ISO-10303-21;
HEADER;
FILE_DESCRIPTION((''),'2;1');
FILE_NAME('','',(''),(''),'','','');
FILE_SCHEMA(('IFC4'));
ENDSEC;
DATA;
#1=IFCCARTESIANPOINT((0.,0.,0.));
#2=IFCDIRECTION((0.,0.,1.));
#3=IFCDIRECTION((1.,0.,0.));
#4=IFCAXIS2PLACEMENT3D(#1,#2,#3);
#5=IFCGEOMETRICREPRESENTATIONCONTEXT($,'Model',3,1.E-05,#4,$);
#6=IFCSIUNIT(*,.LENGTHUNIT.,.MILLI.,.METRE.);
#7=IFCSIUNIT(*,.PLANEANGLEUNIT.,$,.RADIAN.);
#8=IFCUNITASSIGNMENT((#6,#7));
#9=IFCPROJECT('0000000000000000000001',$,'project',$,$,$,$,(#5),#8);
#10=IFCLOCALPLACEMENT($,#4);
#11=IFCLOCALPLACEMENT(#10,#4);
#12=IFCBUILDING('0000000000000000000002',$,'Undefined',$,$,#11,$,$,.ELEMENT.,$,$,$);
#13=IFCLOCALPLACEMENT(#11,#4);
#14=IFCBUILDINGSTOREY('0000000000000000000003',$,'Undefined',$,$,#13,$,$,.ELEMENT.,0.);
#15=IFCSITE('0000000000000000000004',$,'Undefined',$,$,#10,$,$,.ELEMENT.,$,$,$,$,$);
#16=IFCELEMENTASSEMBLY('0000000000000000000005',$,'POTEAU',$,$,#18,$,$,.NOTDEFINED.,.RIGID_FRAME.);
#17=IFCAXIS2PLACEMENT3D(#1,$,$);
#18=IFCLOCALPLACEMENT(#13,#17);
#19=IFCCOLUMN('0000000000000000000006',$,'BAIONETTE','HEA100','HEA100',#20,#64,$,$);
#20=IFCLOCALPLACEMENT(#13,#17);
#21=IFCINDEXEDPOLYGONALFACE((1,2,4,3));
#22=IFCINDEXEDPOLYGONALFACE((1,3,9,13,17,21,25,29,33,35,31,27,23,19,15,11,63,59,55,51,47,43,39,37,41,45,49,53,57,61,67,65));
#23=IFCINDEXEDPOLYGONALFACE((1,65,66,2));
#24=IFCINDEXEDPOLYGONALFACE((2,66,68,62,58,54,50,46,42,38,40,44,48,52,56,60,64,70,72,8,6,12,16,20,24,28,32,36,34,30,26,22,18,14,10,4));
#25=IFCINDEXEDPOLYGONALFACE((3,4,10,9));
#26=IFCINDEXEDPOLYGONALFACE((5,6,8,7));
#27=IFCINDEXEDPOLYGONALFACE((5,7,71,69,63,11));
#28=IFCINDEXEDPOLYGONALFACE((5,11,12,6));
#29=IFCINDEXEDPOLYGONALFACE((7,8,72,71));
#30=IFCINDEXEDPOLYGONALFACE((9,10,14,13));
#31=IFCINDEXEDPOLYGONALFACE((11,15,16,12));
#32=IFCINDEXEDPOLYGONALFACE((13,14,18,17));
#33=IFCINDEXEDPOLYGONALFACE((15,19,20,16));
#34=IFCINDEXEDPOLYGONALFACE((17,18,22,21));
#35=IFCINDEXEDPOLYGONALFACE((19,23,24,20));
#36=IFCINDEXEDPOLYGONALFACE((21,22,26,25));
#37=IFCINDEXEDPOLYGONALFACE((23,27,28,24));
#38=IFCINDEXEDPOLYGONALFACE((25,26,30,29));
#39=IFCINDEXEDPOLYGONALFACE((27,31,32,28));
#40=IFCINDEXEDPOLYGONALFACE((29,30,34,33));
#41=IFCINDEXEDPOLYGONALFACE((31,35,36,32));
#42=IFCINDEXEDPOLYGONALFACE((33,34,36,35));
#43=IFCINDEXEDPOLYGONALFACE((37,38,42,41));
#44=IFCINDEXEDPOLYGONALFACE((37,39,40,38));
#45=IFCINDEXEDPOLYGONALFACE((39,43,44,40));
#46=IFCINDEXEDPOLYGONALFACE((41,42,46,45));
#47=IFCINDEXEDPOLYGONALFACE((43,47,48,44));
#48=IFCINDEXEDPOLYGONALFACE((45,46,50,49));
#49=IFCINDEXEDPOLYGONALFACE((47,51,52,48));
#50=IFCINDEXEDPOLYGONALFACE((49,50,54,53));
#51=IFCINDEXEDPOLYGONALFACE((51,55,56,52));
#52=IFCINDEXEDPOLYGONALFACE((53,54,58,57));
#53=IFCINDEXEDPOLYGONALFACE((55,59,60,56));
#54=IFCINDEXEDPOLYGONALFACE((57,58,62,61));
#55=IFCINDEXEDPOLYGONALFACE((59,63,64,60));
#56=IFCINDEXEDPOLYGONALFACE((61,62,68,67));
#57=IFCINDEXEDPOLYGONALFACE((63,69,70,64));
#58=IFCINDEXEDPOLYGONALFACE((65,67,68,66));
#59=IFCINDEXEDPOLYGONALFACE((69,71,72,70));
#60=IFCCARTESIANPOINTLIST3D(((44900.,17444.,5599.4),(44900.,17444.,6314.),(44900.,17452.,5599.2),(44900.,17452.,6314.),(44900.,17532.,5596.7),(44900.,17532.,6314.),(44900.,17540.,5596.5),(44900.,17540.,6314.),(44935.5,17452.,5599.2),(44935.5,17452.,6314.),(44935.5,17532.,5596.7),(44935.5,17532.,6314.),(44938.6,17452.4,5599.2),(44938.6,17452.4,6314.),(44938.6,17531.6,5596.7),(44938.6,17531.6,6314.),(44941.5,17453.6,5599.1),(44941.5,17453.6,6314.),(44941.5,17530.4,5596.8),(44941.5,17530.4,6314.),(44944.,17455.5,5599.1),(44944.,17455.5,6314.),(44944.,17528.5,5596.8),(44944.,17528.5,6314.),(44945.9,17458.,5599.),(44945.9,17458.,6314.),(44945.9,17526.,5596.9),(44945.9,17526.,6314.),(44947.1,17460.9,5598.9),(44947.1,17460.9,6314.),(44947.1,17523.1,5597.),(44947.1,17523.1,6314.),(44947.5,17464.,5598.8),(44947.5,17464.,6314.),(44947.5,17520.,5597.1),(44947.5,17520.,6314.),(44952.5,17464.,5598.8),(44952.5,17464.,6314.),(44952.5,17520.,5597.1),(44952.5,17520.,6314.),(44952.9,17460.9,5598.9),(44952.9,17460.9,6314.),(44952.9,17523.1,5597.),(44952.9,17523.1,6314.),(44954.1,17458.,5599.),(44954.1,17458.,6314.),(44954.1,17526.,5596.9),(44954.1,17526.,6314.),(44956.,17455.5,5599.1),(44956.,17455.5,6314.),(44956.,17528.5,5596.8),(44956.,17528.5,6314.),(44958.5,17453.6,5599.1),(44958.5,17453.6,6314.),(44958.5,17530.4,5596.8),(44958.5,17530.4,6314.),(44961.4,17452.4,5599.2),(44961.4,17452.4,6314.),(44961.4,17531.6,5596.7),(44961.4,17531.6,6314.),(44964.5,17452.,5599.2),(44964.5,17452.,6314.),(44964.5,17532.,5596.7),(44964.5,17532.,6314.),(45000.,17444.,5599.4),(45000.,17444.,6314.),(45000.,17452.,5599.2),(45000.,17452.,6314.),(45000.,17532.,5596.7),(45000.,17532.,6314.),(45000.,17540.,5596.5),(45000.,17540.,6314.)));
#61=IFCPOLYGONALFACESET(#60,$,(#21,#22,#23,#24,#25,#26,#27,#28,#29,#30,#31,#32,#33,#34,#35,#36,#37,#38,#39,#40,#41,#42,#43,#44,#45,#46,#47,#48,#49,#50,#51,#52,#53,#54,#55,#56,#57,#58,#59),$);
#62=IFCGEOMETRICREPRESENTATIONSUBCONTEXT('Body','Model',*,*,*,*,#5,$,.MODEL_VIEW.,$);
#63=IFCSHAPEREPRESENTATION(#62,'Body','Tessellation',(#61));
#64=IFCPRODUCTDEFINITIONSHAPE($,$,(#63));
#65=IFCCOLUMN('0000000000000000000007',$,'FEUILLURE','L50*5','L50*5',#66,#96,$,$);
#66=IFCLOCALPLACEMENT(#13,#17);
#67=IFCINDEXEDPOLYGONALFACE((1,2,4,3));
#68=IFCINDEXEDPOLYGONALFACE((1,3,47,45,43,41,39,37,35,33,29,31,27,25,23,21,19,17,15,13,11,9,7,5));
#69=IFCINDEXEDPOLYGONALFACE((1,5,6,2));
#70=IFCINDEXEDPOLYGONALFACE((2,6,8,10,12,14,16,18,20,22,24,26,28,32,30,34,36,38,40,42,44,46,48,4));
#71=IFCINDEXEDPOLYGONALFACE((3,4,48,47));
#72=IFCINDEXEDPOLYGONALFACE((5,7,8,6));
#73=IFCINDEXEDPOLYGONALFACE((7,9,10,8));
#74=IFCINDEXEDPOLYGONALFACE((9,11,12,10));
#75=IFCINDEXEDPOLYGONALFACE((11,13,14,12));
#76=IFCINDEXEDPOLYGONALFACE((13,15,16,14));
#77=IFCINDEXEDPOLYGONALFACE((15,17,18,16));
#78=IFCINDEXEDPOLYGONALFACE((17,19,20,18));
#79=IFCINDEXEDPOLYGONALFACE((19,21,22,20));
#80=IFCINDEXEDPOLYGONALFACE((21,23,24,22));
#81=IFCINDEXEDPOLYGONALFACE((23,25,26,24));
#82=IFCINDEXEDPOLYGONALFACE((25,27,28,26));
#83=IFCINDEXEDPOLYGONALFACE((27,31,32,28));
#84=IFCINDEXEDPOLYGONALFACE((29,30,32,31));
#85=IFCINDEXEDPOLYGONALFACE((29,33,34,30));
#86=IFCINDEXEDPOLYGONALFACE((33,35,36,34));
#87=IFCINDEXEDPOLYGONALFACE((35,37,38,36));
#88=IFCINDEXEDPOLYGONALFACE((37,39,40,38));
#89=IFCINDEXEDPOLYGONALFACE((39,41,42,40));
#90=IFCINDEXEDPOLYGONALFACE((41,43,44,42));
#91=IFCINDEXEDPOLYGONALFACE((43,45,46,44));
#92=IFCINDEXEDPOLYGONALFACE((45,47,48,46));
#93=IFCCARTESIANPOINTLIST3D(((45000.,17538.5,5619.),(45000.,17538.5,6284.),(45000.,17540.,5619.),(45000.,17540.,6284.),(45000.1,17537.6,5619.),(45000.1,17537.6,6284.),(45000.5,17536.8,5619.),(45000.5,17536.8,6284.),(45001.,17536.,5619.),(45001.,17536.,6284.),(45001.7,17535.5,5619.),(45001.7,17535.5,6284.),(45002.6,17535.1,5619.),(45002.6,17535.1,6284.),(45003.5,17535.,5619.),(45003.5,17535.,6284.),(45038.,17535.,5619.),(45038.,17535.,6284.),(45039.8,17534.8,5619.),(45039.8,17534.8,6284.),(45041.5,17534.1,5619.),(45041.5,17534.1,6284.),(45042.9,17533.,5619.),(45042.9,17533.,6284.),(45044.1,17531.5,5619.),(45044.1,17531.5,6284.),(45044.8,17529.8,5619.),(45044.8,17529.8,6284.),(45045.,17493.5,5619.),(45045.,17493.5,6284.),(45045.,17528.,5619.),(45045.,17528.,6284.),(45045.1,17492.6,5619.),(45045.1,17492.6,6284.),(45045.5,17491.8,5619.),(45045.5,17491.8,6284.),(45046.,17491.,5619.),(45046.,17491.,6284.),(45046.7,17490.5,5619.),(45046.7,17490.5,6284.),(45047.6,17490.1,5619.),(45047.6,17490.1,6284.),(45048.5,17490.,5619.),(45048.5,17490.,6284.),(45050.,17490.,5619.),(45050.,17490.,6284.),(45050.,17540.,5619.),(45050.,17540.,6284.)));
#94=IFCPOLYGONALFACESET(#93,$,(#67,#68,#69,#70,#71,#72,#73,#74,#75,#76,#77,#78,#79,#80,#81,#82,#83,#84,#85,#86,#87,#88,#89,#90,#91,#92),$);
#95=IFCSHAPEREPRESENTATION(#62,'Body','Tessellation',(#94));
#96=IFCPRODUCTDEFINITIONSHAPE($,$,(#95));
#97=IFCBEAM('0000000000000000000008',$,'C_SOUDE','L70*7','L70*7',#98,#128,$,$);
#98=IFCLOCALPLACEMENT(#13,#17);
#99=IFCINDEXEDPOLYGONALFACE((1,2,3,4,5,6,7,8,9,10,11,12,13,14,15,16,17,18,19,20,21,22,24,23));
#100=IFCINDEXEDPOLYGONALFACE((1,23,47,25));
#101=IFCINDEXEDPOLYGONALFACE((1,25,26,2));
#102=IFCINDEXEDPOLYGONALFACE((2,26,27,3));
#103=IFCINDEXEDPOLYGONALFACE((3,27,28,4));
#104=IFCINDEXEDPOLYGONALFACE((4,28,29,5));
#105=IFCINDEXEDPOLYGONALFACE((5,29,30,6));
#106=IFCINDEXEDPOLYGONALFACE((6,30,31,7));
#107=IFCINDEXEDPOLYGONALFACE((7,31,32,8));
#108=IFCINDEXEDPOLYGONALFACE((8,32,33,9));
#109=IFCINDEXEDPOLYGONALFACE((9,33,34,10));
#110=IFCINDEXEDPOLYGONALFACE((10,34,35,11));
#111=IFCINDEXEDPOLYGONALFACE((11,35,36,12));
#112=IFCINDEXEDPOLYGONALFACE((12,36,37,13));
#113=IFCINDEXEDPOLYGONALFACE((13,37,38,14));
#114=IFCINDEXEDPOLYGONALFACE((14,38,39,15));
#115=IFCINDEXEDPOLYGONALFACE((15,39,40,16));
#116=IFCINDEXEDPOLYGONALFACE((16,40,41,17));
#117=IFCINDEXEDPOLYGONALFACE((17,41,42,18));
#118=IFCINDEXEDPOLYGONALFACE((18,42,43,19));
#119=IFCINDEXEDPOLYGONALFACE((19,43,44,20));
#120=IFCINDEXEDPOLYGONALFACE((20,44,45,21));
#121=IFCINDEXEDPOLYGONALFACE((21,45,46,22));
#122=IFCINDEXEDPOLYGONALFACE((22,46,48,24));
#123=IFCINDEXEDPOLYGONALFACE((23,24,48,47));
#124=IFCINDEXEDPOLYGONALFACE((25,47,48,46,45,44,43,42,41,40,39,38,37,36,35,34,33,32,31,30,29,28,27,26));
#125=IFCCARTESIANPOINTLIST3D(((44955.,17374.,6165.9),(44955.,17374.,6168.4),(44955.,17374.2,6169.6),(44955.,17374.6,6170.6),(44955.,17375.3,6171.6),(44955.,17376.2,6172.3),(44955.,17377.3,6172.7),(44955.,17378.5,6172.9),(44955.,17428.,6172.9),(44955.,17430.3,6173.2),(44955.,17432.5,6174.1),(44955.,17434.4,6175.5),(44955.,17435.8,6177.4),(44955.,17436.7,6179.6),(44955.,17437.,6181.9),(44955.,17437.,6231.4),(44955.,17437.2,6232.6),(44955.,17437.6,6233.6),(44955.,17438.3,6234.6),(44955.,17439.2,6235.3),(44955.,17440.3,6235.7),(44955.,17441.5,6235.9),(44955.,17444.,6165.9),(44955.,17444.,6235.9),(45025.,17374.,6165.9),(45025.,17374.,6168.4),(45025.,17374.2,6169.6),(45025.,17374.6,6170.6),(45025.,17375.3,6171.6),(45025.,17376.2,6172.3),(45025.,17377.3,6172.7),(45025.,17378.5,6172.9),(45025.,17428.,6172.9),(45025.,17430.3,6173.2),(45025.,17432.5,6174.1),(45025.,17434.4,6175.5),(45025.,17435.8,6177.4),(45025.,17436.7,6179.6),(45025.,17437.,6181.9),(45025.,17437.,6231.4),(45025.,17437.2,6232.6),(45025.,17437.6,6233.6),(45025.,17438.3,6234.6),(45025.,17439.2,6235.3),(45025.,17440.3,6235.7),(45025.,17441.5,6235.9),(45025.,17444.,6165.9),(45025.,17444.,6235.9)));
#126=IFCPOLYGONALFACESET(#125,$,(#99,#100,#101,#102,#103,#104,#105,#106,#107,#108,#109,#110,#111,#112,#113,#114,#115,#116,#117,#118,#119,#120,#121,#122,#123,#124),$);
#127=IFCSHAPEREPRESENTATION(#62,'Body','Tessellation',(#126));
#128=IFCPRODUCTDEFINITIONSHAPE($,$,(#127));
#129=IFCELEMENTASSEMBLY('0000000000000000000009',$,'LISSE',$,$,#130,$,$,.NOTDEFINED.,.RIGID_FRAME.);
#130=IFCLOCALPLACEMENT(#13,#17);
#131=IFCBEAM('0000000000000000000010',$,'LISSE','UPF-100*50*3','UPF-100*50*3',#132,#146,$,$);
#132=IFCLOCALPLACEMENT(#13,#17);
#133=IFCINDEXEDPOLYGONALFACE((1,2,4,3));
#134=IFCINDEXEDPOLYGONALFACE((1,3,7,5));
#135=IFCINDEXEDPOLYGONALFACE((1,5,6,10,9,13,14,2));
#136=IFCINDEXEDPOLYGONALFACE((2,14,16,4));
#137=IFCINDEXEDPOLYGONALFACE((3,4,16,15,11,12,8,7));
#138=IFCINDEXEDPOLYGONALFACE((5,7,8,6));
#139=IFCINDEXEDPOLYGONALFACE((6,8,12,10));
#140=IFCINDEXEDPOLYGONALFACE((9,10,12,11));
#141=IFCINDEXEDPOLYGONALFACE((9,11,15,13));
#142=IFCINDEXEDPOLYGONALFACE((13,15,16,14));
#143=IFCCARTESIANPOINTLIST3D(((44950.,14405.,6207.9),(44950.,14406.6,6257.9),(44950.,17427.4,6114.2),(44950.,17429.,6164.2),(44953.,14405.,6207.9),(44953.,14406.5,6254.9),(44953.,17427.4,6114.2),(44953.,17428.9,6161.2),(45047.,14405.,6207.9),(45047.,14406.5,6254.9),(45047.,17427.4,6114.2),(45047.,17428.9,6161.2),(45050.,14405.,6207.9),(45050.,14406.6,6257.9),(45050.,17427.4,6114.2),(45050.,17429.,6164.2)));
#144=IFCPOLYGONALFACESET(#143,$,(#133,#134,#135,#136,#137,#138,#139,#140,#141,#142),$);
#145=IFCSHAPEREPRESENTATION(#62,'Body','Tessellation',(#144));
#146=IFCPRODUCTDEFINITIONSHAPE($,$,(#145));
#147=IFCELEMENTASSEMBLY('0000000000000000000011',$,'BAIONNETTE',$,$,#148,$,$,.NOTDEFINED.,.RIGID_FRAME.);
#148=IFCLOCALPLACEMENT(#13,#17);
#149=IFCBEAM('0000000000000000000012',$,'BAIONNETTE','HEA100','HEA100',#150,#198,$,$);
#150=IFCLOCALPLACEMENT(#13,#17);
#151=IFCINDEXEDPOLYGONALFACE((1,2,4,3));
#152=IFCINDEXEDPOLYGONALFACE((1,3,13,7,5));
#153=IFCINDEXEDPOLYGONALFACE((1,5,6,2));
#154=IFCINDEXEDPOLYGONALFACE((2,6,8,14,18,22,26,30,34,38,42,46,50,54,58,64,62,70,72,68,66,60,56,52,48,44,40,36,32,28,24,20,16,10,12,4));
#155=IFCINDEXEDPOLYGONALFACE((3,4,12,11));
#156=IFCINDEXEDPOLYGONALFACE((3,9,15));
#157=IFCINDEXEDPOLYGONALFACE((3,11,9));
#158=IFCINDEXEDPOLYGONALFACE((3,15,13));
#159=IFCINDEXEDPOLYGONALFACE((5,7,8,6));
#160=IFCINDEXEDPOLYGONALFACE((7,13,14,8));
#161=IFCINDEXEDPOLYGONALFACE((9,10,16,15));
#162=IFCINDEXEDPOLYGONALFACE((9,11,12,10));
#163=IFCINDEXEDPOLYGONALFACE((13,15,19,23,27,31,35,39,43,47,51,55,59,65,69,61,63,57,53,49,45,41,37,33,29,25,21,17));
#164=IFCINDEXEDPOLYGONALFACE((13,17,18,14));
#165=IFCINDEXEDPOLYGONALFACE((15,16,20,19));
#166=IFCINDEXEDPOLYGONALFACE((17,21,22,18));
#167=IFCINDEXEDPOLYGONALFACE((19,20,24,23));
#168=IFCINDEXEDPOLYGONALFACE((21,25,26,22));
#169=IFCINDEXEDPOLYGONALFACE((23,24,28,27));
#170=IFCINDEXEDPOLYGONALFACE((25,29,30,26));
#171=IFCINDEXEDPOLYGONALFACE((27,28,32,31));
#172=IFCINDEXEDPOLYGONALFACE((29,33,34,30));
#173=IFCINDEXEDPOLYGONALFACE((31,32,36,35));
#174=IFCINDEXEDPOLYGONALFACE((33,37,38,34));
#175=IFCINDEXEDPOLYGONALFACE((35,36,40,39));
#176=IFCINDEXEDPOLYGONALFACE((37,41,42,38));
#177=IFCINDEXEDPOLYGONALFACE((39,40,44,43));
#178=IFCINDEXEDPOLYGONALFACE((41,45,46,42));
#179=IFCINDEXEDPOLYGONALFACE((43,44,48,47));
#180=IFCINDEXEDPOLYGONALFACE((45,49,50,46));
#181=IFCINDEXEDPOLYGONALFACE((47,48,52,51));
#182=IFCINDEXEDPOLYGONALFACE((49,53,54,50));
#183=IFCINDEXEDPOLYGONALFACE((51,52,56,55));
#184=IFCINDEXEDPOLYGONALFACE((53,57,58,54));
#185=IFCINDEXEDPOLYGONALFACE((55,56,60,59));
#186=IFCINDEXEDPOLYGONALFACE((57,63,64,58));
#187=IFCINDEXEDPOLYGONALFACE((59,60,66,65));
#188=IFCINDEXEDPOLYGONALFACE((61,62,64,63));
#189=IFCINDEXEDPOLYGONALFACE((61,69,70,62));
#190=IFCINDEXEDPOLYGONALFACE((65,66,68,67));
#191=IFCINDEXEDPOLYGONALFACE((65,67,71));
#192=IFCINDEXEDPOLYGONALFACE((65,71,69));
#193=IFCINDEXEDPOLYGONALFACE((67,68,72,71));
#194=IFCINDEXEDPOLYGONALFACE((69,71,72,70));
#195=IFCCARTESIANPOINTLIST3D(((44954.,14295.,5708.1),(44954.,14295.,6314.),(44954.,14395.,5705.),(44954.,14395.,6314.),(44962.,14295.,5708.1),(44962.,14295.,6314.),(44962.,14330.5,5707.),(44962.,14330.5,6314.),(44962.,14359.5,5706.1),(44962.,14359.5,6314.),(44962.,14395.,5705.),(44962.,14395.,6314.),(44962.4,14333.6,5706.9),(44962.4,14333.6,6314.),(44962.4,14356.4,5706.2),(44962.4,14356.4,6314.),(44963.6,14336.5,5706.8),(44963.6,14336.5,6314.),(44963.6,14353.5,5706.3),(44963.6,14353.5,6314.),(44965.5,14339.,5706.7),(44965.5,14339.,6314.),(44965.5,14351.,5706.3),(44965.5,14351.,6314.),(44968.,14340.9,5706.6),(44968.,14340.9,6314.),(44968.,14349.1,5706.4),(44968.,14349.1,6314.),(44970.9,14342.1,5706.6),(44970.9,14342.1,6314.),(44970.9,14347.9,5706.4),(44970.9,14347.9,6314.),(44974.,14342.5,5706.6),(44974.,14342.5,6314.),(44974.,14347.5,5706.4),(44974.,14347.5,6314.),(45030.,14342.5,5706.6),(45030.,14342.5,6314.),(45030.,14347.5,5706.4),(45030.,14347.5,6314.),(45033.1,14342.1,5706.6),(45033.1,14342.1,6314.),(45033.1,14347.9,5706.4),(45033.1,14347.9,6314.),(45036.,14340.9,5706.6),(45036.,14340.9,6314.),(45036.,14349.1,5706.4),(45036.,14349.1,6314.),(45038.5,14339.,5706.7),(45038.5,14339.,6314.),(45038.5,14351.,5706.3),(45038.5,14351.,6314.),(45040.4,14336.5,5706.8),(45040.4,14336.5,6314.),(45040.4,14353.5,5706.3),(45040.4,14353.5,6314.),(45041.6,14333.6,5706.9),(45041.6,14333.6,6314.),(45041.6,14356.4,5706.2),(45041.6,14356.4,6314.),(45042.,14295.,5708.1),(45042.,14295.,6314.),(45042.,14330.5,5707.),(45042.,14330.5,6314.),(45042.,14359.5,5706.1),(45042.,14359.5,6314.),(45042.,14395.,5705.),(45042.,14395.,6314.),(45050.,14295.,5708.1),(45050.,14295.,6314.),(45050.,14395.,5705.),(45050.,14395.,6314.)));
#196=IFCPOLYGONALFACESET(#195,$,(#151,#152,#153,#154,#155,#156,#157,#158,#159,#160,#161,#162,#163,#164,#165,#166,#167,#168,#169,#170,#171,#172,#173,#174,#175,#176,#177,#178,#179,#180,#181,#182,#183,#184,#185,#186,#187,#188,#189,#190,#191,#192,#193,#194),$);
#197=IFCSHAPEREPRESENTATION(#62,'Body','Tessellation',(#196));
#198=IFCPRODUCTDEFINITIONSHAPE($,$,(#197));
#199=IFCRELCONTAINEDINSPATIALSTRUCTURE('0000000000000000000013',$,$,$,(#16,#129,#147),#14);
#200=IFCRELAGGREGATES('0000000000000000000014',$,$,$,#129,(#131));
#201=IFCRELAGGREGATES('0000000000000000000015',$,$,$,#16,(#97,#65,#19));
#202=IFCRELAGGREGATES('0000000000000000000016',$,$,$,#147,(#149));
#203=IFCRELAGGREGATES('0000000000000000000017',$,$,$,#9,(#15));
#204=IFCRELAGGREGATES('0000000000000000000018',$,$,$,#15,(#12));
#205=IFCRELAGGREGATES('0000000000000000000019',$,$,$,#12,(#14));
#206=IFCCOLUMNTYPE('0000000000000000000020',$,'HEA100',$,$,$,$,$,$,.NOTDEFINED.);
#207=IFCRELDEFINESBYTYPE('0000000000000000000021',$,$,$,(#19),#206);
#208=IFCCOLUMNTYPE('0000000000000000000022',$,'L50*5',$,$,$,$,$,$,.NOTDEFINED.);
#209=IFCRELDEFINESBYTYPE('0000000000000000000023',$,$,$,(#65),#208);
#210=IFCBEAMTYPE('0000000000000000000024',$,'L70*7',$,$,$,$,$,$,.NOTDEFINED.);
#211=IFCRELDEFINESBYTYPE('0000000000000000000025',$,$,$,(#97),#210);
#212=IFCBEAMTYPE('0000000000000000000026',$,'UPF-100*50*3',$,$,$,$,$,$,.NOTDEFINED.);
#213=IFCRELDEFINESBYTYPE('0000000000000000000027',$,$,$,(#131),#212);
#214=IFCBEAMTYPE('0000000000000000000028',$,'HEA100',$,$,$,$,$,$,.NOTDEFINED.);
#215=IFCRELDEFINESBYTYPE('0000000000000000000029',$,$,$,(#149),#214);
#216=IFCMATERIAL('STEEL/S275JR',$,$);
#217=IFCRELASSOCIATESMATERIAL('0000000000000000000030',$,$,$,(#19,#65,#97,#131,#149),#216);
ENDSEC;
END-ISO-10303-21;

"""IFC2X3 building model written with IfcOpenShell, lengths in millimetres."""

from ifc_helpers import new_model, si_unit, frame, origin_with_axes, origin_2d_with_axis, place, context, subcontext, project, spatial, i_section, l_section, u_section, extrude, clip, halfspace, material, type_object, element, aggregate, save


model = new_model("IFC2X3")

# Units and contexts
model_context = context("Model", 3, precision=1e-05, world=origin_with_axes())
body_context = subcontext(model_context, "Body", "Model", "MODEL_VIEW")
ifc_project = project(units=[si_unit("LENGTHUNIT", "METRE", prefix="MILLI"), si_unit("PLANEANGLEUNIT", "RADIAN")], contexts=[model_context])

# Site, building, storey
site_placement = place(None, origin_with_axes())
site = spatial("IfcSite", under=ifc_project, at=site_placement, Name="Undefined", CompositionType="ELEMENT")
building_placement = place(site_placement, origin_with_axes())
building = spatial("IfcBuilding", under=site, at=building_placement, Name="Undefined", CompositionType="ELEMENT")
storey_placement = place(building_placement, origin_with_axes())
storey = spatial("IfcBuildingStorey", under=building, at=storey_placement, Name="Undefined", CompositionType="ELEMENT", Elevation=0.0)

# Element assembly, columns, beam
assembly_1_placement = place(storey_placement, origin_with_axes())
assembly_1 = element("IfcElementAssembly", 1, at=assembly_1_placement, inside=storey, Name="POTEAU", AssemblyPlace="NOTDEFINED", PredefinedType="RIGID_FRAME")
ifc_material_1 = material(Name="STEEL/S275JR")
column_type_1 = type_object("IfcColumnType", Name="HEA100", PredefinedType="NOTDEFINED")
column_1_placement = place(assembly_1_placement, frame((44950.0, 17492.0, 5520.4), z_axis=(0.0, 0.0, 1.0), x_axis=(0.0, -1.0, 0.0)))
column_1 = element("IfcColumn", 2, at=column_1_placement, type_object=column_type_1, material=ifc_material_1, Name="BAIONETTE", Description="HEA100", ObjectType="HEA100", context=body_context, shape_type="Clipping", body=[
    clip(clip(extrude(i_section(OverallWidth=100.0, OverallDepth=96.0, WebThickness=5.0, FlangeThickness=8.0, FilletRadius=12.0, at=origin_2d_with_axis()), frame((0.0, 0.0, 795.1), z_axis=(0.0, 0.0, -1.0), x_axis=(0.0, 1.0, 0.0)), (0.0, 0.0, 1.0), 719.0), halfspace(frame((-37.4, 0.0, 793.6), z_axis=(0.0, 0.0, -1.0), x_axis=(0.0, -1.0, 0.0)), True)), halfspace(frame((-32.3, 0.0, 76.6), z_axis=(0.030985, 0.0, -0.99952), x_axis=(0.99952, 0.0, 0.030985)), False)),
])
column_type_2 = type_object("IfcColumnType", Name="L50*5", PredefinedType="NOTDEFINED")
column_2_placement = place(assembly_1_placement, frame((45025.0, 17515.0, 5619.0), z_axis=(0.0, 0.0, 1.0), x_axis=(-1.0, 0.0, 0.0)))
column_2 = element("IfcColumn", 3, at=column_2_placement, type_object=column_type_2, material=ifc_material_1, Name="FEUILLURE", Description="L50*5", ObjectType="L50*5", context=body_context, shape_type="SweptSolid", body=[
    extrude(l_section(Depth=50.0, Width=50.0, Thickness=5.0, FilletRadius=7.0, EdgeRadius=3.5, at=origin_2d_with_axis()), frame((0.0, 0.0, 665.0), z_axis=(0.0, 0.0, -1.0), x_axis=(0.0, 1.0, 0.0)), (0.0, 0.0, 1.0), 665.0),
])
beam_type_1 = type_object("IfcBeamType", Name="L70*7", PredefinedType="NOTDEFINED")
beam_1_placement = place(assembly_1_placement, frame((45025.0, 17409.0, 6200.9), z_axis=(0.0, -1.0, 0.0), x_axis=(-1.0, 0.0, 0.0)))
beam_1 = element("IfcBeam", 4, at=beam_1_placement, type_object=beam_type_1, material=ifc_material_1, Name="C_SOUDE", Description="L70*7", ObjectType="L70*7", context=body_context, shape_type="SweptSolid", body=[
    extrude(l_section(Depth=70.0, Width=70.0, Thickness=7.0, FilletRadius=9.0, EdgeRadius=4.5, at=origin_2d_with_axis()), frame((70.0, 0.0, 0.0), z_axis=(-1.0, 0.0, 0.0), x_axis=(0.0, -1.0, 0.0)), (0.0, 0.0, 1.0), 70.0),
])

# Element assemblies, beams
assembly_2_placement = place(storey_placement, origin_with_axes())
assembly_2 = element("IfcElementAssembly", 5, at=assembly_2_placement, inside=storey, Name="LISSE", AssemblyPlace="NOTDEFINED", PredefinedType="RIGID_FRAME")
beam_type_2 = type_object("IfcBeamType", Name="UPF-100*50*3", PredefinedType="NOTDEFINED")
beam_2_placement = place(assembly_2_placement, frame((45000.0, 17425.0, 6139.3), z_axis=(-1.0, 0.0, 0.0), x_axis=(0.0, -0.99952, 0.030985)))
beam_2 = element("IfcBeam", 6, at=beam_2_placement, type_object=beam_type_2, material=ifc_material_1, Name="LISSE", Description="UPF-100*50*3", ObjectType="UPF-100*50*3", context=body_context, shape_type="Clipping", body=[
    clip(clip(extrude(u_section(Depth=100.0, FlangeWidth=50.0, WebThickness=3.0, FlangeThickness=3.0, at=origin_2d_with_axis()), frame((3023.8, 0.0, 0.0), z_axis=(-1.0, 0.0, 0.0), x_axis=(0.0, -1.0, 0.0)), (0.0, 0.0, 1.0), 3030.1), halfspace(frame((3020.7, 25.0, -50.0), z_axis=(1.0, 0.0, 0.0), x_axis=(0.0, 0.0, -1.0)), False)), halfspace(frame((-3.2, 25.0, -50.0), z_axis=(1.0, 0.0, 0.0), x_axis=(0.0, 0.0, -1.0)), True)),
])
assembly_3_placement = place(storey_placement, origin_with_axes())
assembly_3 = element("IfcElementAssembly", 7, at=assembly_3_placement, inside=storey, Name="BAIONNETTE", AssemblyPlace="NOTDEFINED", PredefinedType="RIGID_FRAME")
beam_type_3 = type_object("IfcBeamType", Name="HEA100", PredefinedType="NOTDEFINED")
beam_3_placement = place(assembly_3_placement, frame((45002.0, 14345.0, 6346.1), z_axis=(-1.0, 0.0, 0.0), x_axis=(0.0, 0.0, -1.0)))
beam_3 = element("IfcBeam", 8, at=beam_3_placement, type_object=beam_type_3, material=ifc_material_1, Name="BAIONNETTE", Description="HEA100", ObjectType="HEA100", context=body_context, shape_type="Clipping", body=[
    clip(clip(extrude(i_section(OverallWidth=100.0, OverallDepth=96.0, WebThickness=5.0, FlangeThickness=8.0, FilletRadius=12.0, at=origin_2d_with_axis()), frame((641.1, 0.0, 0.0), z_axis=(-1.0, 0.0, 0.0), x_axis=(0.0, -1.0, 0.0)), (0.0, 0.0, 1.0), 610.6), halfspace(frame((639.5, 0.0, -48.0), z_axis=(-0.99952, -0.030986, 0.0), x_axis=(0.0, 0.0, 1.0)), True)), halfspace(frame((32.1, 0.0, -37.4), z_axis=(1.0, 0.0, 0.0), x_axis=(0.0, 0.0, 1.0)), True)),
])

aggregate(assembly_2, [beam_2])
aggregate(assembly_1, [beam_1, column_2, column_1])

aggregate(assembly_3, [beam_3])

save(model, "model.ifc")
